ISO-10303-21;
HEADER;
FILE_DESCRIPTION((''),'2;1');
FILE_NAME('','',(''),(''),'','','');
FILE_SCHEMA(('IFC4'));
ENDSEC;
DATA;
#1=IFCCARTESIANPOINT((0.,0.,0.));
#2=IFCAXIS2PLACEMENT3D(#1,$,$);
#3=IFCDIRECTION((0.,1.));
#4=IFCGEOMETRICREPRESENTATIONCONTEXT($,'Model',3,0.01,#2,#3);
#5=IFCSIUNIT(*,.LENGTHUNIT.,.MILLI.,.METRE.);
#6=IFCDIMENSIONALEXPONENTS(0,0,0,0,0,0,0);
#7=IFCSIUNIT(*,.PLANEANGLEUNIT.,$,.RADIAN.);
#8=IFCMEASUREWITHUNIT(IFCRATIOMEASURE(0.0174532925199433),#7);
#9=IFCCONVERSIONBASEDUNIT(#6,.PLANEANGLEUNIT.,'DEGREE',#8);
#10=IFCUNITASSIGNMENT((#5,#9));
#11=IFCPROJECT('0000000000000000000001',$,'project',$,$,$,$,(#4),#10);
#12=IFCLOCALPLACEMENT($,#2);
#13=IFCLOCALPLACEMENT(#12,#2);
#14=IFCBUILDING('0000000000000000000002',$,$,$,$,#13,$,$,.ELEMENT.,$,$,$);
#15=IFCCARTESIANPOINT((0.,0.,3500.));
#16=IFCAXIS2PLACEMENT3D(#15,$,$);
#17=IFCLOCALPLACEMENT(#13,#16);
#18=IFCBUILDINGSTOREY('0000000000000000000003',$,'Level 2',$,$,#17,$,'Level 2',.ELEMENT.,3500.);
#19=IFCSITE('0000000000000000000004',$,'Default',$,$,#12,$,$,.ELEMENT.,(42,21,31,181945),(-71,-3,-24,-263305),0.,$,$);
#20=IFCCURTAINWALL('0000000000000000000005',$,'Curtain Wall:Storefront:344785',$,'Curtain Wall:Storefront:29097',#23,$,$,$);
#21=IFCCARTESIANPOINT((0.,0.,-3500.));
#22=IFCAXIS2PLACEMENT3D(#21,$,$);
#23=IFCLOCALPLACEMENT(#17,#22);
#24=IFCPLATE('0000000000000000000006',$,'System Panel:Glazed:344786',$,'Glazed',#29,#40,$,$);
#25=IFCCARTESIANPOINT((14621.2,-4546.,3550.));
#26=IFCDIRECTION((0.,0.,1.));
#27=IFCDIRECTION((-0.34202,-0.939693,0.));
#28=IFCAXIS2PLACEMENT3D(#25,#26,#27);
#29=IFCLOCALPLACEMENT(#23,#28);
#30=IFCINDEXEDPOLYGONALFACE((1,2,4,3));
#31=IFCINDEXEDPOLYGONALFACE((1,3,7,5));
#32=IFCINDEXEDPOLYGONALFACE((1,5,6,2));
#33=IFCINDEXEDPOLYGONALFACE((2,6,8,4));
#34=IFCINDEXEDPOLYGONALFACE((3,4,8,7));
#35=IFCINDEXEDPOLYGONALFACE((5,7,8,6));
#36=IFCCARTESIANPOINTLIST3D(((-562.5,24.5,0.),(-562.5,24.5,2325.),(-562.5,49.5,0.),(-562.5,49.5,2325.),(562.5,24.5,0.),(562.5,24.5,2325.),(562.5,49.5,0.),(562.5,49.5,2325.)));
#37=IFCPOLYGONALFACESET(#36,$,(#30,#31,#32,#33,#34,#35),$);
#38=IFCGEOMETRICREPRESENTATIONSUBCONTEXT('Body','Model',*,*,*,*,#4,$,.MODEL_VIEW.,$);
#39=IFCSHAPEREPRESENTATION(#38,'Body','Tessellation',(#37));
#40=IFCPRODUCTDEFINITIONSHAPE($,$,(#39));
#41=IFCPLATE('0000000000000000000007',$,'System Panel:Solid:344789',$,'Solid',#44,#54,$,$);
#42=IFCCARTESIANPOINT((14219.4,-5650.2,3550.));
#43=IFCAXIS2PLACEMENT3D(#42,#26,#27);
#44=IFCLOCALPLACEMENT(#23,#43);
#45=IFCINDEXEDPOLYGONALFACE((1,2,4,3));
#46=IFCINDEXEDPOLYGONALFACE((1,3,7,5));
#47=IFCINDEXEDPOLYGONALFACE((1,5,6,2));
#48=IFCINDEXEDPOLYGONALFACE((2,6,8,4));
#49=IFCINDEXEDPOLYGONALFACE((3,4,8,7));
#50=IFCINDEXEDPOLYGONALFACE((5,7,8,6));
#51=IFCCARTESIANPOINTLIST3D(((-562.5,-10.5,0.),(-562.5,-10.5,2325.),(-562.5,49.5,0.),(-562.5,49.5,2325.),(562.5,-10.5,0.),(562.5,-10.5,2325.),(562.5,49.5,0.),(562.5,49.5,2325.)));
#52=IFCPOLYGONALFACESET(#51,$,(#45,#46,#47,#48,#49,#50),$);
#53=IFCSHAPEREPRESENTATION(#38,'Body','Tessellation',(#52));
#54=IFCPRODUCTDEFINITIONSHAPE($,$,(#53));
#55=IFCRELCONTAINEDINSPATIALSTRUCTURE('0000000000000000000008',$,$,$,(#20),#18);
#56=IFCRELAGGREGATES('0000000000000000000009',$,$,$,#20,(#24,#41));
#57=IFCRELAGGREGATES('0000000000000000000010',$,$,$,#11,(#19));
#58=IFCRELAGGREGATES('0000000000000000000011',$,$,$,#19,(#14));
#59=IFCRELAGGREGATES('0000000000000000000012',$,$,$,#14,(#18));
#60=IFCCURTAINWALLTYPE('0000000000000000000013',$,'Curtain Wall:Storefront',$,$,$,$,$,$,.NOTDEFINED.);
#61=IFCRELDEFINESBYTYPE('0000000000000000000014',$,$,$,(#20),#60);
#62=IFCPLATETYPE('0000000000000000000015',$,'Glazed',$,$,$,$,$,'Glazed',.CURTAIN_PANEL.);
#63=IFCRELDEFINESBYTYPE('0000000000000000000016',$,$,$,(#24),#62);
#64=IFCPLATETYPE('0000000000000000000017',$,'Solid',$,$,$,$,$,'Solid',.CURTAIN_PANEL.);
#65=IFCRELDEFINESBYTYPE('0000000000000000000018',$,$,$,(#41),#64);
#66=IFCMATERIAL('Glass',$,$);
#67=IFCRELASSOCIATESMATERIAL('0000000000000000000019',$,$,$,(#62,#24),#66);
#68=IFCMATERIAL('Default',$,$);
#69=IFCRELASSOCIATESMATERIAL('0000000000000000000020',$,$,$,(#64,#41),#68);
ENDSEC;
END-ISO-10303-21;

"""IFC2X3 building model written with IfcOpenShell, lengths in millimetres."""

from ifc_helpers import new_model, entity, si_unit, converted_unit, direction, frame, origin, origin_2d_with_axis, place, context, subcontext, project, spatial, rectangle, extrude, source, transform, mapped, material, type_object, type_shapes, element, aggregate, save


model = new_model("IFC2X3")

# Units and contexts
model_context = context("Model", 3, precision=0.01, world=origin(), true_north=direction((0.0, 1.0)))
body_context = subcontext(model_context, "Body", "Model", "MODEL_VIEW")
ifc_project = project(units=[si_unit("LENGTHUNIT", "METRE", prefix="MILLI"), converted_unit("PLANEANGLEUNIT", "DEGREE", entity("IfcRatioMeasure", 0.0174532925199433), si_unit("PLANEANGLEUNIT", "RADIAN"), dimensions=[0, 0, 0, 0, 0, 0, 0])], contexts=[model_context])

# Site, building, storey
site_placement = place(None, origin())
site = spatial("IfcSite", under=ifc_project, at=site_placement, Name="Default", CompositionType="ELEMENT", RefLatitude=(42, 21, 31, 181945), RefLongitude=(-71, -3, -24, -263305), RefElevation=0.0)
building_placement = place(site_placement, origin())
building = spatial("IfcBuilding", under=site, at=building_placement, CompositionType="ELEMENT")
storey_placement = place(building_placement, frame((0.0, 0.0, 3500.0)))
storey = spatial("IfcBuildingStorey", under=building, at=storey_placement, Name="Level 2", LongName="Level 2", CompositionType="ELEMENT", Elevation=3500.0)

# Curtain wall, plates
curtain_wall_type = type_object("IfcCurtainWallType", Name="Curtain Wall:Storefront", PredefinedType="NOTDEFINED")
curtain_wall_placement = place(storey_placement, frame((0.0, 0.0, -3500.0)))
curtain_wall = element("IfcCurtainWall", 1, at=curtain_wall_placement, inside=storey, type_object=curtain_wall_type, Name="Curtain Wall:Storefront:344785", ObjectType="Curtain Wall:Storefront:29097")
ifc_material_1 = material(Name="Glass")
plate_type_1 = type_object("IfcPlateType", Name="Glazed", ElementType="Glazed", PredefinedType="CURTAIN_PANEL", material=ifc_material_1)
shared_shape_1 = source(origin(), body_context, "Body", "SweptSolid", [
    extrude(rectangle(XDim=25.0, YDim=1125.0, at=origin_2d_with_axis()), frame((0.0, 37.0, 0.0), z_axis=(0.0, 0.0, 1.0), x_axis=(0.0, 1.0, 0.0)), (0.0, 0.0, 1.0), 2325.0),
])
type_shapes(plate_type_1, [shared_shape_1])
plate_1_placement = place(curtain_wall_placement, frame((14621.2, -4546.0, 3550.0), z_axis=(0.0, 0.0, 1.0), x_axis=(-0.34202, -0.939693, 0.0)))
plate_1 = element("IfcPlate", 2, at=plate_1_placement, type_object=plate_type_1, material=ifc_material_1, Name="System Panel:Glazed:344786", ObjectType="Glazed", context=body_context, shape_type="MappedRepresentation", body=[
    mapped(shared_shape_1, transform((0.0, 0.0, 0.0), scale=1.0)),
])
ifc_material_2 = material(Name="Default")
plate_type_2 = type_object("IfcPlateType", Name="Solid", ElementType="Solid", PredefinedType="CURTAIN_PANEL", material=ifc_material_2)
shared_shape_2 = source(origin(), body_context, "Body", "SweptSolid", [
    extrude(rectangle(XDim=60.0, YDim=1125.0, at=origin_2d_with_axis()), frame((0.0, 19.5, 0.0), z_axis=(0.0, 0.0, 1.0), x_axis=(0.0, 1.0, 0.0)), (0.0, 0.0, 1.0), 2325.0),
])
type_shapes(plate_type_2, [shared_shape_2])
plate_2_placement = place(curtain_wall_placement, frame((14219.4, -5650.2, 3550.0), z_axis=(0.0, 0.0, 1.0), x_axis=(-0.34202, -0.939693, 0.0)))
plate_2 = element("IfcPlate", 3, at=plate_2_placement, type_object=plate_type_2, material=ifc_material_2, Name="System Panel:Solid:344789", ObjectType="Solid", context=body_context, shape_type="MappedRepresentation", body=[
    mapped(shared_shape_2, transform((0.0, 0.0, 0.0), scale=1.0)),
])
aggregate(curtain_wall, [plate_1, plate_2])

save(model, "model.ifc")
